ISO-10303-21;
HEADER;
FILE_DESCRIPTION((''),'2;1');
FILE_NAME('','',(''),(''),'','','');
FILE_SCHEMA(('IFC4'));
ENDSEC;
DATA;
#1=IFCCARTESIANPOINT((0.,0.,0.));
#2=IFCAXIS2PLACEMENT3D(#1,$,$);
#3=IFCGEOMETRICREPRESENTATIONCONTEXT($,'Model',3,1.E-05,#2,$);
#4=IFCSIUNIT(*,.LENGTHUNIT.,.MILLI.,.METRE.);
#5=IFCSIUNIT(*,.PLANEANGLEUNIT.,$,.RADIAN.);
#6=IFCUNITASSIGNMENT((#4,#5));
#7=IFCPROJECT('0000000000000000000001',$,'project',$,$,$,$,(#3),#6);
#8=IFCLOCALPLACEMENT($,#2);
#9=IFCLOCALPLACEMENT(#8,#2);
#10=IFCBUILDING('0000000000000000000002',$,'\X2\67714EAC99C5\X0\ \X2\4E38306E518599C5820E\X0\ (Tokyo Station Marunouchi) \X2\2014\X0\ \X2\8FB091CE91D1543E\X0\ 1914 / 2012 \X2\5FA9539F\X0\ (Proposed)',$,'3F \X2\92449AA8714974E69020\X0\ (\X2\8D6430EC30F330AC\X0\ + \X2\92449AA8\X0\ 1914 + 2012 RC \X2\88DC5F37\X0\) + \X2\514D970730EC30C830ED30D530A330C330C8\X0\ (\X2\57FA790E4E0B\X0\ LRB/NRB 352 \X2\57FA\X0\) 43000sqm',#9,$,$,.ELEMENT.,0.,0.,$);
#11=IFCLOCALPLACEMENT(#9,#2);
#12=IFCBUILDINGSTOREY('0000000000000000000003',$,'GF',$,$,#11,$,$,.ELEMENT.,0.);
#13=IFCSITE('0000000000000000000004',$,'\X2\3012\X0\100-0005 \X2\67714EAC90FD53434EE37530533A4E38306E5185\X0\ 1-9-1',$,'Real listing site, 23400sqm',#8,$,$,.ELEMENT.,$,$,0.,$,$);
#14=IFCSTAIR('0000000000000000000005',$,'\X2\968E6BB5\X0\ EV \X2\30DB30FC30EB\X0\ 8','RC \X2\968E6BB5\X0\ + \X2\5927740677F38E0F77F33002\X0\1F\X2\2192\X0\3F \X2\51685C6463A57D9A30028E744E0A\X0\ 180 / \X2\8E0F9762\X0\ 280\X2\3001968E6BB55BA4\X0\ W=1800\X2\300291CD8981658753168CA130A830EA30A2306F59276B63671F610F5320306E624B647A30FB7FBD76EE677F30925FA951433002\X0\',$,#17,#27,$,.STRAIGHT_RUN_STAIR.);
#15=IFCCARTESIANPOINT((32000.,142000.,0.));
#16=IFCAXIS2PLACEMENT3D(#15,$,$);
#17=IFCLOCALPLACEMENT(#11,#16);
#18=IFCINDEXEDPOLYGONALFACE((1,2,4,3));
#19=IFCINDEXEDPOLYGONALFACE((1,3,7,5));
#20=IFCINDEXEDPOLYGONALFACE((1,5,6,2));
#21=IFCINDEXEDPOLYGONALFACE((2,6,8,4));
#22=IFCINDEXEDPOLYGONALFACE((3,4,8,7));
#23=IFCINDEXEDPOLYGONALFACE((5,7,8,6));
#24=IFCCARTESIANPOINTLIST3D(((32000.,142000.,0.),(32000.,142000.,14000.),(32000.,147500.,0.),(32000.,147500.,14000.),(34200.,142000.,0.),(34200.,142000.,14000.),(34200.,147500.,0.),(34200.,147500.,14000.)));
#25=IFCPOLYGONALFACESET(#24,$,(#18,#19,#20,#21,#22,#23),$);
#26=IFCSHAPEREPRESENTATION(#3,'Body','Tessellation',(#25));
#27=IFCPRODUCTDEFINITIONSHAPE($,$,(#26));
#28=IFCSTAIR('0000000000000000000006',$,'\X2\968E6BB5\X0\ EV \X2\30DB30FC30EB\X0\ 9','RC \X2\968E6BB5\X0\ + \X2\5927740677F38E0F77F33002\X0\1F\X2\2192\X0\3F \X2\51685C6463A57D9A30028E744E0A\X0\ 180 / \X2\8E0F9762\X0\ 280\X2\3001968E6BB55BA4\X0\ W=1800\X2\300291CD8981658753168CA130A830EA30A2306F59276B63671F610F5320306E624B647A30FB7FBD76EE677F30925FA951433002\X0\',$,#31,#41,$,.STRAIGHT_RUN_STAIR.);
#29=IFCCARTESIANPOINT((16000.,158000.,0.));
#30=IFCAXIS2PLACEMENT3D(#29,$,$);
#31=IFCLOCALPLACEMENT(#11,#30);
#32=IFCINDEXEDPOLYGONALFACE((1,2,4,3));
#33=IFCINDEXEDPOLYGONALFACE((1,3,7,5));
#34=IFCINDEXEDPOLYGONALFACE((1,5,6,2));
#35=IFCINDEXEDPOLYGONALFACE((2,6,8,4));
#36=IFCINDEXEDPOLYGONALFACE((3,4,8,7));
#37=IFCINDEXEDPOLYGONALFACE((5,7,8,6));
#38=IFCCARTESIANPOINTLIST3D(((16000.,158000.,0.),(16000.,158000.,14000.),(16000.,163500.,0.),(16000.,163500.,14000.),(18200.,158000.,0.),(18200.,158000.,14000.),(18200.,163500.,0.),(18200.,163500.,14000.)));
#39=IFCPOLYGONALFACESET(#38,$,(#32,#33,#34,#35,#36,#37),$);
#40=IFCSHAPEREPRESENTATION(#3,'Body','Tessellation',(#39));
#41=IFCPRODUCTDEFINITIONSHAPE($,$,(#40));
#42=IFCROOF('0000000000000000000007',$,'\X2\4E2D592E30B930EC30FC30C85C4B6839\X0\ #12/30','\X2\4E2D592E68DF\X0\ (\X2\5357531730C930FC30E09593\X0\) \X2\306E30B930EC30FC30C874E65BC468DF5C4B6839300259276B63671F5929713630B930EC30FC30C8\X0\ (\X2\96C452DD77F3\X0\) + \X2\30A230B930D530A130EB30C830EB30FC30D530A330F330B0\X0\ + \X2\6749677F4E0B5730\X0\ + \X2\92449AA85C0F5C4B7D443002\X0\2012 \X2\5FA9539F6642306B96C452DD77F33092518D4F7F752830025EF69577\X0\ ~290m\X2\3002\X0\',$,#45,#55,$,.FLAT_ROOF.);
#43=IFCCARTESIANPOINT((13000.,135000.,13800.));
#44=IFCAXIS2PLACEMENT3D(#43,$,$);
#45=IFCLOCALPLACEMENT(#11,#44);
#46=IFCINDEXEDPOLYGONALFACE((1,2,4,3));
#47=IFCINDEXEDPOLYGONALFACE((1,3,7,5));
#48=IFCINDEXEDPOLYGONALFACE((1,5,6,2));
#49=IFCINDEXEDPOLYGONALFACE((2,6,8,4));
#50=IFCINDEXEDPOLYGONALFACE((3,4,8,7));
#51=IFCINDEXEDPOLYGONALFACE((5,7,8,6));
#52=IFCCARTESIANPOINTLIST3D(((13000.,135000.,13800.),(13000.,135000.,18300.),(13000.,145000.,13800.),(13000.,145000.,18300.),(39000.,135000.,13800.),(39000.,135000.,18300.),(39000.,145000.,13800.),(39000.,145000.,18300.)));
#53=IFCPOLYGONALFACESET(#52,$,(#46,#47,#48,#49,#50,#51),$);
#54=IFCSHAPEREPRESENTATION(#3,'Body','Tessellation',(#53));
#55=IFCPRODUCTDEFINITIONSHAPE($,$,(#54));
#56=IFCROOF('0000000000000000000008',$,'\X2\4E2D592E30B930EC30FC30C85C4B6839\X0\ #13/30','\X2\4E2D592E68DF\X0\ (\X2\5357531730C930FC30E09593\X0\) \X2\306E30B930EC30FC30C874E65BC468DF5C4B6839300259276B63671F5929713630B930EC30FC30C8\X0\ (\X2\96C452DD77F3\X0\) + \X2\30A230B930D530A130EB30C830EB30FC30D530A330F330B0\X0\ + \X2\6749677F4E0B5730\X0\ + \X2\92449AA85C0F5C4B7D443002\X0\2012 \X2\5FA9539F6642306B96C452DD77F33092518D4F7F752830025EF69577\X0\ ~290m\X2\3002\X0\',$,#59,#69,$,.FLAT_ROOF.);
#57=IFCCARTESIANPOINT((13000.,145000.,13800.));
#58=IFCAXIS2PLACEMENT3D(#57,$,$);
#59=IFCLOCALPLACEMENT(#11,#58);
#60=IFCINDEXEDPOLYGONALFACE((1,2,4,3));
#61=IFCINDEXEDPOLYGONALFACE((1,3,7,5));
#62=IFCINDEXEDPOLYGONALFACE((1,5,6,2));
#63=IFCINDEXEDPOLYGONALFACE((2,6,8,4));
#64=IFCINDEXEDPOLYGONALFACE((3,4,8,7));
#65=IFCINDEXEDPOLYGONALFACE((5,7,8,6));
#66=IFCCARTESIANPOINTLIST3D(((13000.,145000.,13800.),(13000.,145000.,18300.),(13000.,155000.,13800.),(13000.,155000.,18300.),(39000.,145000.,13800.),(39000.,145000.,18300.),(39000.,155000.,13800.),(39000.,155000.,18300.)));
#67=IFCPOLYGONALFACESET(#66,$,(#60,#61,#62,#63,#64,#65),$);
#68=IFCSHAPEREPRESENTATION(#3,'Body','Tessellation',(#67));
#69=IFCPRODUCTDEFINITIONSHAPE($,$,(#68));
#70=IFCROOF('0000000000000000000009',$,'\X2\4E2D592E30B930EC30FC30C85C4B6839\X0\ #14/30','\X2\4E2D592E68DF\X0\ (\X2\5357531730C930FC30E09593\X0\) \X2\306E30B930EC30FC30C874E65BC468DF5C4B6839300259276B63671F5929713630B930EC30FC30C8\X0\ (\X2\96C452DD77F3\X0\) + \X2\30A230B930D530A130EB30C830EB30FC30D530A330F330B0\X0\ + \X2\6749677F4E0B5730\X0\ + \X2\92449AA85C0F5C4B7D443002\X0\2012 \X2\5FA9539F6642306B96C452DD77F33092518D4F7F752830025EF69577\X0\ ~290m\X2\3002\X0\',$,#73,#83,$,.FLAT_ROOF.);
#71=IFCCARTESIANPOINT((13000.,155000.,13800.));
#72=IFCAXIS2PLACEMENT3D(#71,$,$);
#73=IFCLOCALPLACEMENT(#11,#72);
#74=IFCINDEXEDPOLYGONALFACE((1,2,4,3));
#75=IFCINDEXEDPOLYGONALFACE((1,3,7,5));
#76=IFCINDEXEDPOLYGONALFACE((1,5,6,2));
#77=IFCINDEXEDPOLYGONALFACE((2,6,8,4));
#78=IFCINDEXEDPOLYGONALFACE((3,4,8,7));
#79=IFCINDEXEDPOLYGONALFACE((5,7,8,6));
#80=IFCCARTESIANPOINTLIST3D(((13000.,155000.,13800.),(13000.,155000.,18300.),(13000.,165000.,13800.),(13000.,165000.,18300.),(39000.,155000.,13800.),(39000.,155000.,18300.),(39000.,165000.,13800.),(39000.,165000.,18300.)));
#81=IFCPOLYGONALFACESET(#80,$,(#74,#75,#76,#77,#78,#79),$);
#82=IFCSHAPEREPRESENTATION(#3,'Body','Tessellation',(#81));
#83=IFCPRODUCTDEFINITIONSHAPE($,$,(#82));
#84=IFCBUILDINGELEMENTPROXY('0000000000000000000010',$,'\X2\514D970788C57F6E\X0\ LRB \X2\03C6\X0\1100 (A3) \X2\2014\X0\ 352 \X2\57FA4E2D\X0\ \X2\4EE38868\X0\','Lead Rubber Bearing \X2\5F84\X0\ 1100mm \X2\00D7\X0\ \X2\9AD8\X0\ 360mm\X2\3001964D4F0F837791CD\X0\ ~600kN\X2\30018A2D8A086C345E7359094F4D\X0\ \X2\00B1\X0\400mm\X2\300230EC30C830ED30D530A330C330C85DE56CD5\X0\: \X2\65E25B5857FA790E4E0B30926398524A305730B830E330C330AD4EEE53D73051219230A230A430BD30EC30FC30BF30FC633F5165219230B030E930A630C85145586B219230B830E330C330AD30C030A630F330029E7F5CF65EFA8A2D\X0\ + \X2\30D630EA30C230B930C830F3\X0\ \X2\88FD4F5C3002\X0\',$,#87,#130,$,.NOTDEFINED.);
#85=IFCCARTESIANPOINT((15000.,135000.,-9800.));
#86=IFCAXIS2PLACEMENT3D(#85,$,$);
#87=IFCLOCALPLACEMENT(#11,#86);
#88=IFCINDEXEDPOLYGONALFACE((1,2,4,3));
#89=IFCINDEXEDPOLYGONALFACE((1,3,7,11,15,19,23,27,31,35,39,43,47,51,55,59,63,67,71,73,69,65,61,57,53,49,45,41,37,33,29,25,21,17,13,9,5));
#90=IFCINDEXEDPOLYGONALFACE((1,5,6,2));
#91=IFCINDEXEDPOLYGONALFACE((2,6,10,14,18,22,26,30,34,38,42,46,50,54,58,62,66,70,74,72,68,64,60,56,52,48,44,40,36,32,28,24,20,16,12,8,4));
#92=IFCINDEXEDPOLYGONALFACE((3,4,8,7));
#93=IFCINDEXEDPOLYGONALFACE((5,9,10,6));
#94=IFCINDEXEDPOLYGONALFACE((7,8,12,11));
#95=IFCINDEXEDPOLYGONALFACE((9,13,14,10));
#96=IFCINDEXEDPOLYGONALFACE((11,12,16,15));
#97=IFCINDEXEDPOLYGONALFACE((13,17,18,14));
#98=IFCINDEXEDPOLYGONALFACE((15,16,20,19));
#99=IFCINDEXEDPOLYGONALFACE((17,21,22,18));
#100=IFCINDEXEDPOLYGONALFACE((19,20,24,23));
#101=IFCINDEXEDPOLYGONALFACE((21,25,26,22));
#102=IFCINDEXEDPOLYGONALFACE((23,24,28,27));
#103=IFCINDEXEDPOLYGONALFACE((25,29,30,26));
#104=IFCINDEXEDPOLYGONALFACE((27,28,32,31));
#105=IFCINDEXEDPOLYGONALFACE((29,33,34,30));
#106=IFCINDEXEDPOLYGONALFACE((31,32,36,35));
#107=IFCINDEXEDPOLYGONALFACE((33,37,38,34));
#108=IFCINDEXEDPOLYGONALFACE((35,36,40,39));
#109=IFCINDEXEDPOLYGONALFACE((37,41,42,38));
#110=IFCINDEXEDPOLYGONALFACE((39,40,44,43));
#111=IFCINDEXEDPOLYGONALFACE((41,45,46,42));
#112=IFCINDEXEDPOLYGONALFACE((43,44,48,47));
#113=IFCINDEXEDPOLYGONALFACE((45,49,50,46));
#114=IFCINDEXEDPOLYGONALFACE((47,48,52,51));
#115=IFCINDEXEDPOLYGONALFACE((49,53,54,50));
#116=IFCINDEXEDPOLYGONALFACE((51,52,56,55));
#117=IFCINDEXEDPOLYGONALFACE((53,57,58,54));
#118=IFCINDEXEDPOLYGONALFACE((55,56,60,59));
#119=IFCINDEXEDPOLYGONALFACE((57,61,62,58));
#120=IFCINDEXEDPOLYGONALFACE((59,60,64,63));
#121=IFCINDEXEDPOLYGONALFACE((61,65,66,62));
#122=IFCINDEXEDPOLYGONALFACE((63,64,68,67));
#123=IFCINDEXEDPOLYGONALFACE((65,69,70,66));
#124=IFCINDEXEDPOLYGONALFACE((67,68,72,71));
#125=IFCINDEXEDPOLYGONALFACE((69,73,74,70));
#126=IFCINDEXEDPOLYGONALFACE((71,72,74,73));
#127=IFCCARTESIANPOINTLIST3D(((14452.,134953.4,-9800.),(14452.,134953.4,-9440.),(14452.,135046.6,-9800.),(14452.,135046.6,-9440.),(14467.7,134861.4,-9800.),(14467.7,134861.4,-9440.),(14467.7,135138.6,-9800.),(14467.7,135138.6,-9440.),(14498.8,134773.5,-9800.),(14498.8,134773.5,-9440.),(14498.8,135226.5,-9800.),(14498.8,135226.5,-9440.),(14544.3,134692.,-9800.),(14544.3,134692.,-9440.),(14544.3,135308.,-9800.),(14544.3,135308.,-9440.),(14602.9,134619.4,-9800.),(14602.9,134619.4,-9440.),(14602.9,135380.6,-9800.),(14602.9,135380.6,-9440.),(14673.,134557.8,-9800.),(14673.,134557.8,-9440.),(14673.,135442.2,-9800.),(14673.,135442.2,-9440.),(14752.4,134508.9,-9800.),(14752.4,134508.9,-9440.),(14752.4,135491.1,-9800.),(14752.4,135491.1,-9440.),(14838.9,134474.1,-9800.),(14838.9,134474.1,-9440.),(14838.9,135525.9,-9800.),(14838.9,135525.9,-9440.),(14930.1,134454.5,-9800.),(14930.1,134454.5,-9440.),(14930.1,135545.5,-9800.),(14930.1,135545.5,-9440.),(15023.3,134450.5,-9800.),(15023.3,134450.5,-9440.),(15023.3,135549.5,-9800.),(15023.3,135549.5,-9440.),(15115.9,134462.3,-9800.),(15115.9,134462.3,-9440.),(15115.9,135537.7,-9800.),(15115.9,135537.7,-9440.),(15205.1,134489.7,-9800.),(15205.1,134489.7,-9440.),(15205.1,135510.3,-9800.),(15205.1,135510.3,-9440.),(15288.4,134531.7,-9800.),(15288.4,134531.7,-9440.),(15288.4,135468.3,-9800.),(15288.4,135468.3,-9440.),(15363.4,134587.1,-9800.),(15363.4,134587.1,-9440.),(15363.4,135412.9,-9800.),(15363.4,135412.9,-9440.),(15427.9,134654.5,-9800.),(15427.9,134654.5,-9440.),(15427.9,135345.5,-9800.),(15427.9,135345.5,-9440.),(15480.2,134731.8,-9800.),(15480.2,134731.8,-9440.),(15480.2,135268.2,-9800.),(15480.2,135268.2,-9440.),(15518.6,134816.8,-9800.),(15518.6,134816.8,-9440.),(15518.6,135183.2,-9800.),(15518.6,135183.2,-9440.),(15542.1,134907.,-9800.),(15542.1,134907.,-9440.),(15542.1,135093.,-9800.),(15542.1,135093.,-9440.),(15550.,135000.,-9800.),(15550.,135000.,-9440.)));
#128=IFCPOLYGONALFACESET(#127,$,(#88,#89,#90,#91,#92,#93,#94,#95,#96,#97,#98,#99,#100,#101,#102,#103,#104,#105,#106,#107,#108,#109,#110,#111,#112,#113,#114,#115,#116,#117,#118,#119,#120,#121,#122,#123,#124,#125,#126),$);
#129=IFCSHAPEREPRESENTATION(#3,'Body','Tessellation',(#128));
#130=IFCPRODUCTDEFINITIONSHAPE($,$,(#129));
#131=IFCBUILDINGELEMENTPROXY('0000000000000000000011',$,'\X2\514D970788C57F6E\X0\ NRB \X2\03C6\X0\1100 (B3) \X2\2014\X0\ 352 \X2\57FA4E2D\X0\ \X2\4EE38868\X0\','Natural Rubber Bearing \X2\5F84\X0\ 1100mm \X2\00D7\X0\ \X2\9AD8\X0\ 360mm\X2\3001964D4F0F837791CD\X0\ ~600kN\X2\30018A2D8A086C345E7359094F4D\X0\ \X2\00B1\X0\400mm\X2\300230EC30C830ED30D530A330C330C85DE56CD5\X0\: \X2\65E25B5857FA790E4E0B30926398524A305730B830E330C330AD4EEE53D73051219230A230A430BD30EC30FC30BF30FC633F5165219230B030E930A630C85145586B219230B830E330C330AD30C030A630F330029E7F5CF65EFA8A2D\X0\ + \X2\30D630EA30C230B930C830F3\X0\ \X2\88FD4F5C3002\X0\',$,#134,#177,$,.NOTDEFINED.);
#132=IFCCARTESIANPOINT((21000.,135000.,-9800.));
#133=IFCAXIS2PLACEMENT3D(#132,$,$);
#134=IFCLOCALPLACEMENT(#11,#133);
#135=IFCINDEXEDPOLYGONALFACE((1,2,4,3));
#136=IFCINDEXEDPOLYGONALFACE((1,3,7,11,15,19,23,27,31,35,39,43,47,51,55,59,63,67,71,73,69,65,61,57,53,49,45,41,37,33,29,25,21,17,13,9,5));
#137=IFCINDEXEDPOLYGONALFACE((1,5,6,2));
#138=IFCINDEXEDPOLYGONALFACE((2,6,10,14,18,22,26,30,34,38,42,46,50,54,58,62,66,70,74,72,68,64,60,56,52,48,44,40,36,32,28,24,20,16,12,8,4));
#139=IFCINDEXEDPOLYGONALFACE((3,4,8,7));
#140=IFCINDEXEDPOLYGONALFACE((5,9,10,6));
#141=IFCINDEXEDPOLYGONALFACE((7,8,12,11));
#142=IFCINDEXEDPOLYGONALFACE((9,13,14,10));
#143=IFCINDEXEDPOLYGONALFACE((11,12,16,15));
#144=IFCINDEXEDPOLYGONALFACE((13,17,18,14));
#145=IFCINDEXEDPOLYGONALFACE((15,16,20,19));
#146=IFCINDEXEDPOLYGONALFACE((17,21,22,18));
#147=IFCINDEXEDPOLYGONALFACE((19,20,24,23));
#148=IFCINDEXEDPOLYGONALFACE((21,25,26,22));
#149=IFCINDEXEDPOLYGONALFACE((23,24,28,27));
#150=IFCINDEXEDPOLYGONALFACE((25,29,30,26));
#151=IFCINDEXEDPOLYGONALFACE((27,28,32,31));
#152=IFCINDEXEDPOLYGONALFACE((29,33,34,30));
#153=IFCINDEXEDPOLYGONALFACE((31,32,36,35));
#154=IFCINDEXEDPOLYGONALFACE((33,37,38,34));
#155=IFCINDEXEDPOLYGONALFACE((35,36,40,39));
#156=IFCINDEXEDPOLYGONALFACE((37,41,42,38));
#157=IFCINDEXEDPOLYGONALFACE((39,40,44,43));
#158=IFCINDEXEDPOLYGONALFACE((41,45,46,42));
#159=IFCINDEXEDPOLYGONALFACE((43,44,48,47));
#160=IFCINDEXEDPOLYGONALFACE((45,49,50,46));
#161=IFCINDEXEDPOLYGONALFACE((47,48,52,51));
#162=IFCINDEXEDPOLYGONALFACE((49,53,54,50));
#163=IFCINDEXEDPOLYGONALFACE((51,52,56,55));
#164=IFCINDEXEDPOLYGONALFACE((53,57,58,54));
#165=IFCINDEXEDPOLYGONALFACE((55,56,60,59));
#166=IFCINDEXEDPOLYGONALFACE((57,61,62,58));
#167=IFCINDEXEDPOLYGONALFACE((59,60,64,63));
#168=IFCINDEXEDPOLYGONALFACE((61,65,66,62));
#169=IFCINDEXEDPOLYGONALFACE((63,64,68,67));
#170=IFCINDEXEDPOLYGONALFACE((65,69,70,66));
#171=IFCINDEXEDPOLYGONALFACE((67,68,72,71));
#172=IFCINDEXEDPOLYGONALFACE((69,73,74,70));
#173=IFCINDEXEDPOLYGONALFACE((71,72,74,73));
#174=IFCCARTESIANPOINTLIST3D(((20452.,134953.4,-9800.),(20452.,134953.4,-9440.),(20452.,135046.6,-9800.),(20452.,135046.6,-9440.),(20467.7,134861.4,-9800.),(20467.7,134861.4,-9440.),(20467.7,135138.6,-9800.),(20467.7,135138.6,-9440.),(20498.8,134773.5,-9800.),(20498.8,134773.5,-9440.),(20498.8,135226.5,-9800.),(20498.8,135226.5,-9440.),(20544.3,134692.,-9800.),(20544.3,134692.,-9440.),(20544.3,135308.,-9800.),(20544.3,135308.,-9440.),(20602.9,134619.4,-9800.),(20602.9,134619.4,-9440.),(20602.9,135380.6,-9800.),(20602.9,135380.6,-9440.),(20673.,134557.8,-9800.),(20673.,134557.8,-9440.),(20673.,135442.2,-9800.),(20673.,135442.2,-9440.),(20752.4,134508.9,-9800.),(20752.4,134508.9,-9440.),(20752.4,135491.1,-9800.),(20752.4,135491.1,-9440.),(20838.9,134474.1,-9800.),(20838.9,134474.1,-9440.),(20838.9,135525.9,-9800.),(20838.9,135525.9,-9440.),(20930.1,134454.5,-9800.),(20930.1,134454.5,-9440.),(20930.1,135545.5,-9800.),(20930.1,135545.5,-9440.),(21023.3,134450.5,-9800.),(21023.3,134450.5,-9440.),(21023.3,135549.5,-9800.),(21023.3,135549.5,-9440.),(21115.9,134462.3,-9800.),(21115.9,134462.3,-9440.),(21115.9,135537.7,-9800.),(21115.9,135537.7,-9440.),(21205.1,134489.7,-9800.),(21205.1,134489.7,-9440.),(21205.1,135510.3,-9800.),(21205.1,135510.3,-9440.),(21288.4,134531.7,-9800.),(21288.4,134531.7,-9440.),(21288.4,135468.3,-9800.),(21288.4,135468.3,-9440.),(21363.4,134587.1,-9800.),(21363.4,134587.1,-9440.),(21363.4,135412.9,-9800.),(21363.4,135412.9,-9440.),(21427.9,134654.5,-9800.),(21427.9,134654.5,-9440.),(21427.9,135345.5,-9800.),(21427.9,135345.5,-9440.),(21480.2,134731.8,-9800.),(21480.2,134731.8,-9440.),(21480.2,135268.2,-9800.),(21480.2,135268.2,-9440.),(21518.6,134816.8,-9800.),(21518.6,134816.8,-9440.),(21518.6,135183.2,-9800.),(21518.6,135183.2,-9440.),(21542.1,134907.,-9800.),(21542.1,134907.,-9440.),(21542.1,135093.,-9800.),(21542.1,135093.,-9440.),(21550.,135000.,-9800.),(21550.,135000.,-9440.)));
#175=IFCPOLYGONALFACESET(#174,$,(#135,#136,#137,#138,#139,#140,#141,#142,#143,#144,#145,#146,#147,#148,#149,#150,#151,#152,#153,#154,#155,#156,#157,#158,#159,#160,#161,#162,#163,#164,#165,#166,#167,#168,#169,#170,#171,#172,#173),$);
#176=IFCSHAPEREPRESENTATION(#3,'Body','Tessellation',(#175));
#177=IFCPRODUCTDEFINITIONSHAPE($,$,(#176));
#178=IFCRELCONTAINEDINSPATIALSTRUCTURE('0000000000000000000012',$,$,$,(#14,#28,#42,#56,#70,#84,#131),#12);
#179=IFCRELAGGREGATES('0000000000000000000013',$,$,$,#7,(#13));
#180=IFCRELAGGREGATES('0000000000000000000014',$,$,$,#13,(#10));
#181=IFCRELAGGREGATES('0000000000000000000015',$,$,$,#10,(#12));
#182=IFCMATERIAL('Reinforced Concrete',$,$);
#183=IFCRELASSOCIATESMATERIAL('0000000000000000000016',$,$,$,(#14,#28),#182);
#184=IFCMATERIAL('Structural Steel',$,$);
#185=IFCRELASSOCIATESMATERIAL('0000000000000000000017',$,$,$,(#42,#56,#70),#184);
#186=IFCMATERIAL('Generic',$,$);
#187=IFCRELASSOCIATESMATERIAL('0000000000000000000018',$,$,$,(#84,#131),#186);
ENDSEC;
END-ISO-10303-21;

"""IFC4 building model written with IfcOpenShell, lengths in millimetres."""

from ifc_helpers import new_model, si_unit, frame, frame_2d, origin, origin_2d, place, context, project, spatial, rectangle, circle, extrude, material, element, save


model = new_model("IFC4")

# Units and contexts
model_context = context("Model", 3, precision=1e-05, world=origin())
ifc_project = project(units=[si_unit("LENGTHUNIT", "METRE", prefix="MILLI"), si_unit("PLANEANGLEUNIT", "RADIAN")], contexts=[model_context])

# Site, building, storey
site_placement = place(None, origin())
site = spatial("IfcSite", under=ifc_project, at=site_placement, Name="〒100-0005 東京都千代田区丸の内 1-9-1", ObjectType="Real listing site, 23400sqm", CompositionType="ELEMENT", RefElevation=0.0)
building_placement = place(site_placement, origin())
building = spatial("IfcBuilding", under=site, at=building_placement, Name="東京駅 丸の内駅舎 (Tokyo Station Marunouchi) — 辰野金吾 1914 / 2012 復原 (Proposed)", ObjectType="3F 鉄骨煉瓦造 (赤レンガ + 鉄骨 1914 + 2012 RC 補強) + 免震レトロフィット (基礎下 LRB/NRB 352 基) 43000sqm", CompositionType="ELEMENT", ElevationOfRefHeight=0.0, ElevationOfTerrain=0.0)
storey_placement = place(building_placement, origin())
storey = spatial("IfcBuildingStorey", under=building, at=storey_placement, Name="GF", CompositionType="ELEMENT", Elevation=0.0)

# Shared definitions
ifc_material_1 = material(Name="Structural Steel")

# Stairs
ifc_material_2 = material(Name="Reinforced Concrete")
stair_1_placement = place(storey_placement, frame((32000.0, 142000.0, 0.0)))
element("IfcStair", 1, at=stair_1_placement, inside=storey, material=ifc_material_2, Name="階段 EV ホール 8", Description="RC 階段 + 大理石踏石。1F→3F 全層接続。蹴上 180 / 踏面 280、階段室 W=1800。重要文化財エリアは大正期意匠の手摺・羽目板を復元。", PredefinedType="STRAIGHT_RUN_STAIR", context=model_context, shape_type="SweptSolid", body=[
    extrude(rectangle(XDim=2200.0, YDim=5500.0, at=frame_2d((1100.0, 2750.0))), frame((32000.0, 142000.0, 0.0)), (0.0, 0.0, 1.0), 14000.0),
])
stair_2_placement = place(storey_placement, frame((16000.0, 158000.0, 0.0)))
element("IfcStair", 2, at=stair_2_placement, inside=storey, material=ifc_material_2, Name="階段 EV ホール 9", Description="RC 階段 + 大理石踏石。1F→3F 全層接続。蹴上 180 / 踏面 280、階段室 W=1800。重要文化財エリアは大正期意匠の手摺・羽目板を復元。", PredefinedType="STRAIGHT_RUN_STAIR", context=model_context, shape_type="SweptSolid", body=[
    extrude(rectangle(XDim=2200.0, YDim=5500.0, at=frame_2d((1100.0, 2750.0))), frame((16000.0, 158000.0, 0.0)), (0.0, 0.0, 1.0), 14000.0),
])

# Roofs
roof_1_placement = place(storey_placement, frame((13000.0, 135000.0, 13800.0)))
element("IfcRoof", 3, at=roof_1_placement, inside=storey, material=ifc_material_1, Name="中央スレート屋根 #12/30", Description="中央棟 (南北ドーム間) のスレート瓦寄棟屋根。大正期天然スレート (雄勝石) + アスファルトルーフィング + 杉板下地 + 鉄骨小屋組。2012 復原時に雄勝石を再使用。延長 ~290m。", PredefinedType="FLAT_ROOF", context=model_context, shape_type="SweptSolid", body=[
    extrude(rectangle(XDim=26000.0, YDim=10000.0, at=frame_2d((13000.0, 5000.0))), frame((13000.0, 135000.0, 13800.0)), (0.0, 0.0, 1.0), 4500.0),
])
roof_2_placement = place(storey_placement, frame((13000.0, 145000.0, 13800.0)))
element("IfcRoof", 4, at=roof_2_placement, inside=storey, material=ifc_material_1, Name="中央スレート屋根 #13/30", Description="中央棟 (南北ドーム間) のスレート瓦寄棟屋根。大正期天然スレート (雄勝石) + アスファルトルーフィング + 杉板下地 + 鉄骨小屋組。2012 復原時に雄勝石を再使用。延長 ~290m。", PredefinedType="FLAT_ROOF", context=model_context, shape_type="SweptSolid", body=[
    extrude(rectangle(XDim=26000.0, YDim=10000.0, at=frame_2d((13000.0, 5000.0))), frame((13000.0, 145000.0, 13800.0)), (0.0, 0.0, 1.0), 4500.0),
])
roof_3_placement = place(storey_placement, frame((13000.0, 155000.0, 13800.0)))
element("IfcRoof", 5, at=roof_3_placement, inside=storey, material=ifc_material_1, Name="中央スレート屋根 #14/30", Description="中央棟 (南北ドーム間) のスレート瓦寄棟屋根。大正期天然スレート (雄勝石) + アスファルトルーフィング + 杉板下地 + 鉄骨小屋組。2012 復原時に雄勝石を再使用。延長 ~290m。", PredefinedType="FLAT_ROOF", context=model_context, shape_type="SweptSolid", body=[
    extrude(rectangle(XDim=26000.0, YDim=10000.0, at=frame_2d((13000.0, 5000.0))), frame((13000.0, 155000.0, 13800.0)), (0.0, 0.0, 1.0), 4500.0),
])

# Building element proxies
ifc_material_3 = material(Name="Generic")
proxy_1_placement = place(storey_placement, frame((15000.0, 135000.0, -9800.0)))
element("IfcBuildingElementProxy", 6, at=proxy_1_placement, inside=storey, material=ifc_material_3, Name="免震装置 LRB φ1100 (A3) — 352 基中 代表", Description="Lead Rubber Bearing 径 1100mm × 高 360mm、降伏荷重 ~600kN、設計水平変位 ±400mm。レトロフィット工法: 既存基礎下を掘削しジャッキ仮受け→アイソレーター挿入→グラウト充填→ジャッキダウン。鹿島建設 + ブリヂストン 製作。", PredefinedType="NOTDEFINED", context=model_context, shape_type="SweptSolid", body=[
    extrude(circle(Radius=550.0, at=origin_2d()), frame((15000.0, 135000.0, -9800.0)), (0.0, 0.0, 1.0), 360.0),
])
proxy_2_placement = place(storey_placement, frame((21000.0, 135000.0, -9800.0)))
element("IfcBuildingElementProxy", 7, at=proxy_2_placement, inside=storey, material=ifc_material_3, Name="免震装置 NRB φ1100 (B3) — 352 基中 代表", Description="Natural Rubber Bearing 径 1100mm × 高 360mm、降伏荷重 ~600kN、設計水平変位 ±400mm。レトロフィット工法: 既存基礎下を掘削しジャッキ仮受け→アイソレーター挿入→グラウト充填→ジャッキダウン。鹿島建設 + ブリヂストン 製作。", PredefinedType="NOTDEFINED", context=model_context, shape_type="SweptSolid", body=[
    extrude(circle(Radius=550.0, at=origin_2d()), frame((21000.0, 135000.0, -9800.0)), (0.0, 0.0, 1.0), 360.0),
])

save(model, "model.ifc")
